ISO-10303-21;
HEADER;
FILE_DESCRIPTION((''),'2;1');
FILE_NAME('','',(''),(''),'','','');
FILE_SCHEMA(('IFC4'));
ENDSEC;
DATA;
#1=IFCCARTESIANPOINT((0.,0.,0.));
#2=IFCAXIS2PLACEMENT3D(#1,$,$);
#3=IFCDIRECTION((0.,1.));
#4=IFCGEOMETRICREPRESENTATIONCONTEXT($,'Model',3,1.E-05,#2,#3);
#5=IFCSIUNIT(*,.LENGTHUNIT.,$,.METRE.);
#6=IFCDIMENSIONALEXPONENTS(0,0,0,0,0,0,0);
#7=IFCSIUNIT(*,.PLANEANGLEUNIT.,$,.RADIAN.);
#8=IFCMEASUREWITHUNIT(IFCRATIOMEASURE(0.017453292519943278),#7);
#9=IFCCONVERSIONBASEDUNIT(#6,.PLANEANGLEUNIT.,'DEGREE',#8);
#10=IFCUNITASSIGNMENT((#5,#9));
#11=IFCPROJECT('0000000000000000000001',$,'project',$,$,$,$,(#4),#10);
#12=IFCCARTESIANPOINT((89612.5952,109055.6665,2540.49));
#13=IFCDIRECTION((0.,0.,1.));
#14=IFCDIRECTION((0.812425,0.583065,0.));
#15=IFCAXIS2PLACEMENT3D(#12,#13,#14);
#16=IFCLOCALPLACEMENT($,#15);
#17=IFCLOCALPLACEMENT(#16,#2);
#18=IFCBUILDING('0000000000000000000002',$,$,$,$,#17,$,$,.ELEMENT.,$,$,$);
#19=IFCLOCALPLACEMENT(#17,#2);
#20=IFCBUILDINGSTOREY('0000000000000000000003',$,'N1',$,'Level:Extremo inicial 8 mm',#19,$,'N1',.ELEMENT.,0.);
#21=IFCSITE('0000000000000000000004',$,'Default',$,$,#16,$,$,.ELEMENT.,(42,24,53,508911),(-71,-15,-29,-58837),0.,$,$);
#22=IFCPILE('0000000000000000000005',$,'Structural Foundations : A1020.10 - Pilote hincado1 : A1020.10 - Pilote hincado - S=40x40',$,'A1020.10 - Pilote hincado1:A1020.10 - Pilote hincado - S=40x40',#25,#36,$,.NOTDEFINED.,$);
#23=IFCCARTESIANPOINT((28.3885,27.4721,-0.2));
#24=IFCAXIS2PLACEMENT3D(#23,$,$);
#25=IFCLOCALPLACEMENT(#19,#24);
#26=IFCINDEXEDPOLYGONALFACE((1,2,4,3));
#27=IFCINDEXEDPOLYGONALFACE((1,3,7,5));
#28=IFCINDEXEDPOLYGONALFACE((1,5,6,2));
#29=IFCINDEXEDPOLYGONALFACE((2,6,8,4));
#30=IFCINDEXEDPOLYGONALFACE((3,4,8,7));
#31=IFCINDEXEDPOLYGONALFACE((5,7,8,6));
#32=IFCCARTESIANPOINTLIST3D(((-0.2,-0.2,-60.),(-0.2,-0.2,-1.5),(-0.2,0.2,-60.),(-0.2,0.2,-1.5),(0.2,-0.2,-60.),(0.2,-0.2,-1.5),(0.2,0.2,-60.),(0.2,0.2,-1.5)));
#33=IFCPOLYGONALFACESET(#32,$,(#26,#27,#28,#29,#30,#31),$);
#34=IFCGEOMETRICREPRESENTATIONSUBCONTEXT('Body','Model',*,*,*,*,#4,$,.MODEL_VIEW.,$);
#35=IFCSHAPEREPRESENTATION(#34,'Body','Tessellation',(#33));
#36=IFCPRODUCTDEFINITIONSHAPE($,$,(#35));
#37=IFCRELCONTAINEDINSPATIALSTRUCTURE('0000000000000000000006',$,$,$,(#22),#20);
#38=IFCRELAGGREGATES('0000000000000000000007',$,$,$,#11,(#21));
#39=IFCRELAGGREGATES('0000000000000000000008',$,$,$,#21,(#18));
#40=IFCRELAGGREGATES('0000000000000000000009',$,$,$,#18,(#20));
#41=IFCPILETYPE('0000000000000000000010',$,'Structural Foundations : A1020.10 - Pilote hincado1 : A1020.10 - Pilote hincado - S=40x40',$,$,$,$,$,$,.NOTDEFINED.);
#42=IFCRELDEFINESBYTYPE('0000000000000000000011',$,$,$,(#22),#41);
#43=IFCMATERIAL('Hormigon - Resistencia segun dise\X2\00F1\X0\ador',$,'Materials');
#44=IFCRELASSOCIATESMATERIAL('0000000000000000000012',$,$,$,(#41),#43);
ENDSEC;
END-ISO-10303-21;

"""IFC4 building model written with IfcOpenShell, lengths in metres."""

from ifc_helpers import new_model, entity, si_unit, converted_unit, direction, frame, origin, origin_2d_with_axis, place, context, subcontext, project, spatial, polyline, segment, composite_curve, rectangle, outline, extrude, source, transform, mapped, material, material_profile, profile_set, type_object, type_shapes, element, save


model = new_model("IFC4")

# Units and contexts
model_context = context("Model", 3, precision=1e-05, world=origin(), true_north=direction((0.0, 1.0)))
body_context = subcontext(model_context, "Body", "Model", "MODEL_VIEW")
ifc_project = project(units=[si_unit("LENGTHUNIT", "METRE"), converted_unit("PLANEANGLEUNIT", "DEGREE", entity("IfcRatioMeasure", 0.017453292519943278), si_unit("PLANEANGLEUNIT", "RADIAN"), dimensions=[0, 0, 0, 0, 0, 0, 0])], contexts=[model_context])

# Site, building, storey
site_placement = place(None, frame((89612.5952, 109055.6665, 2540.49), z_axis=(0.0, 0.0, 1.0), x_axis=(0.812425, 0.583065, 0.0)))
site = spatial("IfcSite", under=ifc_project, at=site_placement, Name="Default", CompositionType="ELEMENT", RefLatitude=(42, 24, 53, 508911), RefLongitude=(-71, -15, -29, -58837), RefElevation=0.0)
building_placement = place(site_placement, origin())
building = spatial("IfcBuilding", under=site, at=building_placement, CompositionType="ELEMENT")
storey_placement = place(building_placement, origin())
storey = spatial("IfcBuildingStorey", under=building, at=storey_placement, Name="N1", ObjectType="Level:Extremo inicial 8 mm", LongName="N1", CompositionType="ELEMENT", Elevation=0.0)

# Pile
ifc_material_1 = material(Name="Hormigon - Resistencia segun diseñador", Category="Materials")
ifc_material_profile_1 = material_profile(ifc_material_1, outline(composite_curve([segment(polyline([(0.2, 0.2, -60.0), (0.2, -0.2, -60.0)]), True, "CONTINUOUS"), segment(polyline([(0.2, -0.2, -60.0), (-0.2, -0.2, -60.0)]), True, "CONTINUOUS"), segment(polyline([(-0.2, -0.2, -60.0), (-0.2, 0.2, -60.0)]), True, "CONTINUOUS"), segment(polyline([(-0.2, 0.2, -60.0), (0.2, 0.2, -60.0)]), True, "CONTINUOUS")], self_intersect=False), kind="CURVE"), Name="A1020.10 - Pilote hincado - S=40x40")
ifc_profile_set_1 = profile_set([ifc_material_profile_1], Name="A1020.10 - Pilote hincado - S=40x40")
pile_type_1 = type_object("IfcPileType", Name="Structural Foundations : A1020.10 - Pilote hincado1 : A1020.10 - Pilote hincado - S=40x40", PredefinedType="NOTDEFINED", material=ifc_profile_set_1)
shared_shape_1 = source(origin(), body_context, "Body", "SweptSolid", [
    extrude(rectangle(XDim=0.4, YDim=0.4, at=origin_2d_with_axis()), frame((0.0, 0.0, -60.0), z_axis=(0.0, 0.0, 1.0), x_axis=(0.0, -1.0, 0.0)), (0.0, 0.0, 1.0), 58.5),
])
type_shapes(pile_type_1, [shared_shape_1])
for number, where, name in (
    (1, (28.3885, 27.4721, -0.2), "Structural Foundations : A1020.10 - Pilote hincado1 : A1020.10 - Pilote hincado - S=40x40"),
):
    element("IfcPile", number, at=place(storey_placement, frame(where)), inside=storey, type_object=pile_type_1, Name=name, ObjectType="A1020.10 - Pilote hincado1:A1020.10 - Pilote hincado - S=40x40", PredefinedType="NOTDEFINED", context=body_context, shape_type="MappedRepresentation", body=[
        mapped(shared_shape_1, transform((0.0, 0.0, 0.0), scale=1.0)),
    ])

save(model, "model.ifc")
